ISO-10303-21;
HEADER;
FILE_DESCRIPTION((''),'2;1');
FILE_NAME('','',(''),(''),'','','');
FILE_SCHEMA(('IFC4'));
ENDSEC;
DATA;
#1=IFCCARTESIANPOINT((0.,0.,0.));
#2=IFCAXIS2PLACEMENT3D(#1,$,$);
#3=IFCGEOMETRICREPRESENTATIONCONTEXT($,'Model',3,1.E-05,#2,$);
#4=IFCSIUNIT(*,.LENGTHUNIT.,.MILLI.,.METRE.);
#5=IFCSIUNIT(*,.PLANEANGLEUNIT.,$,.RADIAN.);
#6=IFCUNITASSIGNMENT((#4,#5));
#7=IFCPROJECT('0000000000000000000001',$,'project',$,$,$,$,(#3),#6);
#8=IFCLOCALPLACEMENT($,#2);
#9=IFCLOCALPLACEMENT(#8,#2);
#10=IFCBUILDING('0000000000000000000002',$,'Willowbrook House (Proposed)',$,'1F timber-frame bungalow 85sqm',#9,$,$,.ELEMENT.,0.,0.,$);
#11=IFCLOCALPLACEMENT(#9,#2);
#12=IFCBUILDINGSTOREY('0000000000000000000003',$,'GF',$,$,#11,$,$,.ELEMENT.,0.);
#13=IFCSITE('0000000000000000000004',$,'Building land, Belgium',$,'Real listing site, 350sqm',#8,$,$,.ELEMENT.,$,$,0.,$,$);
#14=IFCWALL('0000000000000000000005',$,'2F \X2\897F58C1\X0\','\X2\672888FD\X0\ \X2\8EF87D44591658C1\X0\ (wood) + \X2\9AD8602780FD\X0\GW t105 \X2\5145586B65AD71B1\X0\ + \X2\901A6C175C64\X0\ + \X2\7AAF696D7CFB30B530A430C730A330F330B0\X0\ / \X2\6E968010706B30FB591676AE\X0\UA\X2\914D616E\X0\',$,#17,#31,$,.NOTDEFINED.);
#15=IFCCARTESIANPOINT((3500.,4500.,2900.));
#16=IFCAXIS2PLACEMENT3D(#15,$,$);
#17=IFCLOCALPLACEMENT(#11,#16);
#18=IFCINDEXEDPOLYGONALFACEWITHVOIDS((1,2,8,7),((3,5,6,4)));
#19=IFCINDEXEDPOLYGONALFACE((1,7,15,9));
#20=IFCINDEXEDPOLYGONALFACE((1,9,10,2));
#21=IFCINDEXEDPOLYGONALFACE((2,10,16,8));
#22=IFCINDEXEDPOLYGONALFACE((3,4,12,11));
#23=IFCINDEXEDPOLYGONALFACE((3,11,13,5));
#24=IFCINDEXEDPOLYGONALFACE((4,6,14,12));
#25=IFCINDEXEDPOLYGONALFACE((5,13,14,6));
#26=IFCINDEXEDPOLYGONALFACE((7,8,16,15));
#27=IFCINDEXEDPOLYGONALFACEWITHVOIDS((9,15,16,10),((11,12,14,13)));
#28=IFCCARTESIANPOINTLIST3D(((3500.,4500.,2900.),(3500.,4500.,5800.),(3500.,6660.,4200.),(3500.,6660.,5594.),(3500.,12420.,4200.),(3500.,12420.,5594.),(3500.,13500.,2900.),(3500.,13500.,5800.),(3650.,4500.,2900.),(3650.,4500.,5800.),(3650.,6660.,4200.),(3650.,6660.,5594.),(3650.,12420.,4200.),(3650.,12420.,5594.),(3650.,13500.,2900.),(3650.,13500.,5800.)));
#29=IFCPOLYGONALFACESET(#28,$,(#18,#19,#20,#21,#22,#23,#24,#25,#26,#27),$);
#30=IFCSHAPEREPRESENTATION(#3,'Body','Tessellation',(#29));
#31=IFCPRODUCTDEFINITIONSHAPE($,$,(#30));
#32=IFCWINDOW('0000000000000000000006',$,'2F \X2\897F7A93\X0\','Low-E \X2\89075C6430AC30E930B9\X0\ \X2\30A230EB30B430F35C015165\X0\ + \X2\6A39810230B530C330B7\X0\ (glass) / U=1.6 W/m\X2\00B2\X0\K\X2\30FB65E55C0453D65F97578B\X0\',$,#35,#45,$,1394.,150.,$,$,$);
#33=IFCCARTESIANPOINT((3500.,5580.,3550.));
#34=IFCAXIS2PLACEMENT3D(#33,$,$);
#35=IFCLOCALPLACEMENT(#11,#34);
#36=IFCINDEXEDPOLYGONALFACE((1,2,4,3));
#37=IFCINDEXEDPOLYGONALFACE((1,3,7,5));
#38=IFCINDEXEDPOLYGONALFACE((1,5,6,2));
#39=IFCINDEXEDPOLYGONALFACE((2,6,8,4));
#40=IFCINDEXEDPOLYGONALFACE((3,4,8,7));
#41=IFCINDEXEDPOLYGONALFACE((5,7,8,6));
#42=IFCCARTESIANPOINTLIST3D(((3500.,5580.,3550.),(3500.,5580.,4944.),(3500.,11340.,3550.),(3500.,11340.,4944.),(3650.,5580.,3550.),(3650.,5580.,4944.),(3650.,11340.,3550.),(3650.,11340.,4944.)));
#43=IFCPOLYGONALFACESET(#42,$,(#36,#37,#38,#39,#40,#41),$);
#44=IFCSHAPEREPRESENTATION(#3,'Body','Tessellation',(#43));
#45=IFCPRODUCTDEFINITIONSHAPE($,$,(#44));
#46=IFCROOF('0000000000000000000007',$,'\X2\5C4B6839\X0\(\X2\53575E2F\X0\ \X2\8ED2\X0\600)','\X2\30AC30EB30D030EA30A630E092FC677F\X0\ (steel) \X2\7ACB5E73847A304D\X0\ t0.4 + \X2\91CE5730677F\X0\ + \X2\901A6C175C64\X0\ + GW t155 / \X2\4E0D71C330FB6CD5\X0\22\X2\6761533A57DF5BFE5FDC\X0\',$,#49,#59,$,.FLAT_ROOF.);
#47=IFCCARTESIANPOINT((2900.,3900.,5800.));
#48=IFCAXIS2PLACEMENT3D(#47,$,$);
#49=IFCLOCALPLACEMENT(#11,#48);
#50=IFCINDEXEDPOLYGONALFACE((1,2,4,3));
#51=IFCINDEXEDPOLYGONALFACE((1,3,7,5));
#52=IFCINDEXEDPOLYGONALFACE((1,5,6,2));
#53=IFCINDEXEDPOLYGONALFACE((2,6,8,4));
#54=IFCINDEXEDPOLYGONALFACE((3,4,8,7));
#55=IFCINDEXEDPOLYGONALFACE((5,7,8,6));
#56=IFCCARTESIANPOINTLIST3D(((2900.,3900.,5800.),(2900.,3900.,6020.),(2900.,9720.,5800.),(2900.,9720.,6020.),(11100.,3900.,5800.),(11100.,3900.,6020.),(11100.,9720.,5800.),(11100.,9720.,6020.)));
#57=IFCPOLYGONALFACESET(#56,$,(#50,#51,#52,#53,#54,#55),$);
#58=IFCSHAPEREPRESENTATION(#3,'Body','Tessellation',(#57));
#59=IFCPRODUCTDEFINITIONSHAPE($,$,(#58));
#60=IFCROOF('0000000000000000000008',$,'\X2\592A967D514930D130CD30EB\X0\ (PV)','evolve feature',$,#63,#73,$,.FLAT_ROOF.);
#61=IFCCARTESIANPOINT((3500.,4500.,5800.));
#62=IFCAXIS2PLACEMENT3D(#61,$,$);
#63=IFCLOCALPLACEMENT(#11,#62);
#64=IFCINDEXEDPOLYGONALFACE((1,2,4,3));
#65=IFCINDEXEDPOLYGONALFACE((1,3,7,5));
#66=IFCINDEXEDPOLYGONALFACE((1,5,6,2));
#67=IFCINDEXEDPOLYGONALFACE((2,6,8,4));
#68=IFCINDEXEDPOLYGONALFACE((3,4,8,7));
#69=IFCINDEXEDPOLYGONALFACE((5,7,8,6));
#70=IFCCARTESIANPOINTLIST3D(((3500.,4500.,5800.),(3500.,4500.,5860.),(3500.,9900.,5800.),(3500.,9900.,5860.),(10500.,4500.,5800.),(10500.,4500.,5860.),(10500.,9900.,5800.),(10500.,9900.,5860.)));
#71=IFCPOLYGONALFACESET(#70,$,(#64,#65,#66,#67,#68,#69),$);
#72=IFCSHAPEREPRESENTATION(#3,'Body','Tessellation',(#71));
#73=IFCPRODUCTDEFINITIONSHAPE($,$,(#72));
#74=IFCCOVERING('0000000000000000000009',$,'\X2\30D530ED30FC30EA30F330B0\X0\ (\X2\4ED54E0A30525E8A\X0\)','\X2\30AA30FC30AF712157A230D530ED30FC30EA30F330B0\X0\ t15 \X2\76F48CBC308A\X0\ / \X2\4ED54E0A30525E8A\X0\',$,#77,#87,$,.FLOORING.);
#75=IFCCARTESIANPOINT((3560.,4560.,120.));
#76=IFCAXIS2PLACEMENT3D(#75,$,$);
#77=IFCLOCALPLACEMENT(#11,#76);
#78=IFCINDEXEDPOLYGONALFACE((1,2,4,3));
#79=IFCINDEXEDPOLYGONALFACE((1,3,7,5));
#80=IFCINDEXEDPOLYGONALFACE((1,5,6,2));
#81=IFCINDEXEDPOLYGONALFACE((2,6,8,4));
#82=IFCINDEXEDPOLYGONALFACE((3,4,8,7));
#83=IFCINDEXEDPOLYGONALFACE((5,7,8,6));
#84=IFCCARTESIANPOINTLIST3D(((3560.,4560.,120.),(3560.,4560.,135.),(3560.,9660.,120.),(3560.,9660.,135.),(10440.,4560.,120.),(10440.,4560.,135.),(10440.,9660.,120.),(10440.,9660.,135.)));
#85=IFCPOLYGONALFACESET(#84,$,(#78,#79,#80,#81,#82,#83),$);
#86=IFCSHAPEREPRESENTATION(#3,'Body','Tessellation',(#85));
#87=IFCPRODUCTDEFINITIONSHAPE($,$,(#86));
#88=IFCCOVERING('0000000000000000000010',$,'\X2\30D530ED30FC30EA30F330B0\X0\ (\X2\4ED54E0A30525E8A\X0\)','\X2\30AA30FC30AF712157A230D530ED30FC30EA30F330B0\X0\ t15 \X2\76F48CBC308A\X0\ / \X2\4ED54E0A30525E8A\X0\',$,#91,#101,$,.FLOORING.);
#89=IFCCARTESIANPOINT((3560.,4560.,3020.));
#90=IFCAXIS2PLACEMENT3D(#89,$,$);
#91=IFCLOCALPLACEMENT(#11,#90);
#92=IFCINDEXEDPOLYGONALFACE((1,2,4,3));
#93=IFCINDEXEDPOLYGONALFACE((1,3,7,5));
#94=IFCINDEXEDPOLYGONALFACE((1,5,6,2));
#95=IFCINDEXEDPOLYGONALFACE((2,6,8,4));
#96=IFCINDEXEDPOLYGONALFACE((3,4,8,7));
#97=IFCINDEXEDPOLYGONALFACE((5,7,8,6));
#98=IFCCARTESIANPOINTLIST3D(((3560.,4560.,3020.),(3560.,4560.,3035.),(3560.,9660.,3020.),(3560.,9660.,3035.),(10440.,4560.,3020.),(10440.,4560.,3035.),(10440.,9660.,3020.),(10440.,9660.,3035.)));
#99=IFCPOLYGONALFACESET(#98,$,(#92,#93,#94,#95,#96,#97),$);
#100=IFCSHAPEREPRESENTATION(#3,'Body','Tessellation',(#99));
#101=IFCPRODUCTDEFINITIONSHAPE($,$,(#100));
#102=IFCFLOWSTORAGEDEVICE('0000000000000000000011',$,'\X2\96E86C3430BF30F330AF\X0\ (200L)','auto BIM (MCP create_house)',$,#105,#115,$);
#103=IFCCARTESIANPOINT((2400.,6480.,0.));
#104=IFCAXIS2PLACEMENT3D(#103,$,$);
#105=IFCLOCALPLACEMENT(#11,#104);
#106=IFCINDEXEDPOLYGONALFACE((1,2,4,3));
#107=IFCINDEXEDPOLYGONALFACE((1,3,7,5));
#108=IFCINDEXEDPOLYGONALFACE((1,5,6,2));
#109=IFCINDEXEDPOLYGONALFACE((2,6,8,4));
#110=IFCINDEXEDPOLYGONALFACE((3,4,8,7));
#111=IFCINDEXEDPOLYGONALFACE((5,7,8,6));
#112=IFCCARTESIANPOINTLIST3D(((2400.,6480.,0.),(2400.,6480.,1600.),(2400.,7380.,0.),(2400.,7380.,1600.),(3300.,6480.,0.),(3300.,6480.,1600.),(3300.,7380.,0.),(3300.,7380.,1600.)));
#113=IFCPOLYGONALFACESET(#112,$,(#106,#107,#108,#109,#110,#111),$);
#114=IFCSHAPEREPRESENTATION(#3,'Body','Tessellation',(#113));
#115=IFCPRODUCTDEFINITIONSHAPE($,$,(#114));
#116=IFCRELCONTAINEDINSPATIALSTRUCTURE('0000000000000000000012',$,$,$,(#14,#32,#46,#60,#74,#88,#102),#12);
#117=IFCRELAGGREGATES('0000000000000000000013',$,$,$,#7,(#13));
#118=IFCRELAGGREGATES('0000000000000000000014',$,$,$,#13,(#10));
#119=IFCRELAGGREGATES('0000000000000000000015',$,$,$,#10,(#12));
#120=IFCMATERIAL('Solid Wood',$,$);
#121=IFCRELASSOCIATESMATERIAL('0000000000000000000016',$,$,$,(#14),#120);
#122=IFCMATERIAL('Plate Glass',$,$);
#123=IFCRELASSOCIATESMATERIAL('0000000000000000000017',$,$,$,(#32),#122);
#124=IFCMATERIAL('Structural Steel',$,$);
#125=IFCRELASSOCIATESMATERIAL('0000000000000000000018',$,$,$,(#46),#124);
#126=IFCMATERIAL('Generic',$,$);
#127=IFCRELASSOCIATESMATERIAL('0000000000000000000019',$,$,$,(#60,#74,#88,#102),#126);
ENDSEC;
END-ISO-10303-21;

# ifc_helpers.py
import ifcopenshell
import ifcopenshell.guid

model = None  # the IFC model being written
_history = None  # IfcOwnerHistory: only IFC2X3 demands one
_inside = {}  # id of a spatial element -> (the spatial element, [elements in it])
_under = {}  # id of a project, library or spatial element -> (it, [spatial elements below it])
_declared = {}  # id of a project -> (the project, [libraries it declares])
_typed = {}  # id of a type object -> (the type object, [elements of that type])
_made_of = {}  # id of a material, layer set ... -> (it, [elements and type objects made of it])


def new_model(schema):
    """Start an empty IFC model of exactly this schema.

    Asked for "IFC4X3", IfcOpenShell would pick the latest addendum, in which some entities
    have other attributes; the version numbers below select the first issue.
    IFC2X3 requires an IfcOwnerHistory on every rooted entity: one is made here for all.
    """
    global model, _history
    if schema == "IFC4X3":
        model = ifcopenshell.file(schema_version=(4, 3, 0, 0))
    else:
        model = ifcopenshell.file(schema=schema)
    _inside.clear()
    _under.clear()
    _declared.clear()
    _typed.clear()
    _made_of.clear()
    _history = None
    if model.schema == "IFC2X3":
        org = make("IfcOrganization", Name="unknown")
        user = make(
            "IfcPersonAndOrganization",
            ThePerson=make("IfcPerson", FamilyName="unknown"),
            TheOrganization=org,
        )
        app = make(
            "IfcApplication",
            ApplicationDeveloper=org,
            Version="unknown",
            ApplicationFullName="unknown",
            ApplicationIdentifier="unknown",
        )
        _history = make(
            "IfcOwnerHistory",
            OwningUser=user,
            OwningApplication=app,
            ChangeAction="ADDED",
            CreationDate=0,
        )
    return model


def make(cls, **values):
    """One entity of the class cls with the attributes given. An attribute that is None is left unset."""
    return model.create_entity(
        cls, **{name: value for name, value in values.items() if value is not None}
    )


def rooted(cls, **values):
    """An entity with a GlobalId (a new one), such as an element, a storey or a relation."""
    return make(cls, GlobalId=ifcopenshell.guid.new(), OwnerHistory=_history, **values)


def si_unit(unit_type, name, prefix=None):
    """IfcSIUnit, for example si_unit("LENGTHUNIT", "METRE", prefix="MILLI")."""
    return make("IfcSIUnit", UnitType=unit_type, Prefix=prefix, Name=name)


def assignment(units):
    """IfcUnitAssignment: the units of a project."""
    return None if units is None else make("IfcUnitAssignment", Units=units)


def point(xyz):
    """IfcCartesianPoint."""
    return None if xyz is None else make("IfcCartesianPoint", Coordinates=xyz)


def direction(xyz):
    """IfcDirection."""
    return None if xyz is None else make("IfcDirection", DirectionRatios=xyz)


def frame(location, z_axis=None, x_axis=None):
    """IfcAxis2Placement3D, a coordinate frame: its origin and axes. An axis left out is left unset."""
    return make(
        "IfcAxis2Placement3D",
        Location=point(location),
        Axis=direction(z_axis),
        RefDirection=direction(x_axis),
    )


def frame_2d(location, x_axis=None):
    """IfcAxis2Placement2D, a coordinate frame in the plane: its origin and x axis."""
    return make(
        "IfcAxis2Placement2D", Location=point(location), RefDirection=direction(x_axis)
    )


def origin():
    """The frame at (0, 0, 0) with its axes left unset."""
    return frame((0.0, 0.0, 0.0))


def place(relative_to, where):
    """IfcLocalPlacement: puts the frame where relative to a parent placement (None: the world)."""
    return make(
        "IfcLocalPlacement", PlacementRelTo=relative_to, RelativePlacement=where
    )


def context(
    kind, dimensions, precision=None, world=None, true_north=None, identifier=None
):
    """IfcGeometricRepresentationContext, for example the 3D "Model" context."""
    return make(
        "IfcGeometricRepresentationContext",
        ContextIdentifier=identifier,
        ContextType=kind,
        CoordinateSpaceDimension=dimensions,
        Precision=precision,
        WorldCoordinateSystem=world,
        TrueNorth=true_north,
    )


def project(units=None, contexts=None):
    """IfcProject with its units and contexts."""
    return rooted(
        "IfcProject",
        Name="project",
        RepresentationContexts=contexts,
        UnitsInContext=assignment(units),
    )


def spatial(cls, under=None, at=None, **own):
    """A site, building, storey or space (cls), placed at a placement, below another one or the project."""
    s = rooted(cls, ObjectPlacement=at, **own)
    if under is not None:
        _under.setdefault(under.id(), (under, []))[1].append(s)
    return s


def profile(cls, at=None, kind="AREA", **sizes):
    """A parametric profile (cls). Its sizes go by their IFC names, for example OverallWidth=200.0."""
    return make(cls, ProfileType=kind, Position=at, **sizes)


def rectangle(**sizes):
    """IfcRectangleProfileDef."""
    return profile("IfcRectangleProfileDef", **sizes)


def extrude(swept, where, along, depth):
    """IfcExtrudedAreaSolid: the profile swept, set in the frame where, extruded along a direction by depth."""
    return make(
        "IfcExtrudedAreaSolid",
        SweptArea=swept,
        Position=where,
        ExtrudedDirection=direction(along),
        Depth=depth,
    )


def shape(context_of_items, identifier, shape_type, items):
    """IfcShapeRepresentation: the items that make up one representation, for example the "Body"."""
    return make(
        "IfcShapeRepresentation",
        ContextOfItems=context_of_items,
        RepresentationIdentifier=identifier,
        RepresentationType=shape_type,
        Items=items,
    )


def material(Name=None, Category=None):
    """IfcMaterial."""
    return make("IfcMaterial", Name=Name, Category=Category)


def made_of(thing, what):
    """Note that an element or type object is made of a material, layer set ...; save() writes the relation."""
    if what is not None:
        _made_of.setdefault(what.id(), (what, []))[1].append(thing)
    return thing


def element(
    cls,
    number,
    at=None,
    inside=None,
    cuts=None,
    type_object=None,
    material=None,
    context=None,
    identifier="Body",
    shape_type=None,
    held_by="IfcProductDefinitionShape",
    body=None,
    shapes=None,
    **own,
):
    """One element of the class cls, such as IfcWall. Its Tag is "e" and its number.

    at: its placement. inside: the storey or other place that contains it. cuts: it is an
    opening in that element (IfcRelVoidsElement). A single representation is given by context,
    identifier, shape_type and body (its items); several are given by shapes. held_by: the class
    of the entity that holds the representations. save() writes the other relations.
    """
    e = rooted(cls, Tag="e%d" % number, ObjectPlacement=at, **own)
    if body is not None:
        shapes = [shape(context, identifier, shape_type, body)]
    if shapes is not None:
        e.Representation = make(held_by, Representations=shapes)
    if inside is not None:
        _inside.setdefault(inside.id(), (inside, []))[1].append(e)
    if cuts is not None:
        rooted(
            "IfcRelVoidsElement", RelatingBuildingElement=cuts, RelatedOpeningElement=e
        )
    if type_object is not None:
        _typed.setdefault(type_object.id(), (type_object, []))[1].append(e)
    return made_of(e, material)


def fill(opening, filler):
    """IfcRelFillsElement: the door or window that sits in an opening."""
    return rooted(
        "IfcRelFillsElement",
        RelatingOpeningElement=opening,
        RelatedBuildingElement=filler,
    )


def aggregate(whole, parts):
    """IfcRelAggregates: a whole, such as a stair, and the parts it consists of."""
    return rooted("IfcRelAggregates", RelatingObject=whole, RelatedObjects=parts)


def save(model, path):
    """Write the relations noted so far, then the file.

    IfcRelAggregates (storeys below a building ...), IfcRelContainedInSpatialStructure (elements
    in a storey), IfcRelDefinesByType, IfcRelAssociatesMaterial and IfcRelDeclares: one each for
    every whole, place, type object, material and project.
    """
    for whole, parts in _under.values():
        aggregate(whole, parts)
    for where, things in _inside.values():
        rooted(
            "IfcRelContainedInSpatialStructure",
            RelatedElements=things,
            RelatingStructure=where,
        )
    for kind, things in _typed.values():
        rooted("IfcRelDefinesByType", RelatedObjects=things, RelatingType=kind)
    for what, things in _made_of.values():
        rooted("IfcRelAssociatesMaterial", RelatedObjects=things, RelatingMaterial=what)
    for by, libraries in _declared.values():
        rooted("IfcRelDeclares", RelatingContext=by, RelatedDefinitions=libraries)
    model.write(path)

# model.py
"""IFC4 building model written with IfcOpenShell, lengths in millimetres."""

from ifc_helpers import new_model, si_unit, frame, frame_2d, origin, place, context, project, spatial, rectangle, extrude, material, element, fill, save


model = new_model("IFC4")

# Units and contexts
model_context = context("Model", 3, precision=1e-05, world=origin())
ifc_project = project(units=[si_unit("LENGTHUNIT", "METRE", prefix="MILLI"), si_unit("PLANEANGLEUNIT", "RADIAN")], contexts=[model_context])

# Site, building, storey
site_placement = place(None, origin())
site = spatial("IfcSite", under=ifc_project, at=site_placement, Name="Building land, Belgium", ObjectType="Real listing site, 350sqm", CompositionType="ELEMENT", RefElevation=0.0)
building_placement = place(site_placement, origin())
building = spatial("IfcBuilding", under=site, at=building_placement, Name="Willowbrook House (Proposed)", ObjectType="1F timber-frame bungalow 85sqm", CompositionType="ELEMENT", ElevationOfRefHeight=0.0, ElevationOfTerrain=0.0)
storey_placement = place(building_placement, origin())
storey = spatial("IfcBuildingStorey", under=building, at=storey_placement, Name="GF", CompositionType="ELEMENT", Elevation=0.0)

# Shared definitions
ifc_material_1 = material(Name="Solid Wood")
ifc_material_2 = material(Name="Generic")

# Shared definitions
ifc_material_3 = material(Name="Plate Glass")

# Wall, opening, window
wall_1_placement = place(storey_placement, frame((3500.0, 4500.0, 2900.0)))
wall_1 = element("IfcWall", 1, at=wall_1_placement, inside=storey, material=ifc_material_1, Name="2F 西壁", Description="木製 軸組外壁 (wood) + 高性能GW t105 充填断熱 + 通気層 + 窯業系サイディング / 準耐火・外皮UA配慮", PredefinedType="NOTDEFINED", context=model_context, shape_type="SweptSolid", body=[
    extrude(rectangle(XDim=150.0, YDim=9000.0, at=frame_2d((75.0, 4500.0))), frame((3500.0, 4500.0, 2900.0)), (0.0, 0.0, 1.0), 2900.0),
])
opening_1_placement = place(storey_placement, frame((3500.0, 5580.0, 3550.0)))
opening_1 = element("IfcOpeningElement", 2, at=opening_1_placement, cuts=wall_1, PredefinedType="NOTDEFINED", context=model_context, shape_type="SweptSolid", body=[
    extrude(rectangle(XDim=150.0, YDim=5760.0, at=frame_2d((75.0, 2880.0))), frame((3500.0, 5580.0, 3550.0)), (0.0, 0.0, 1.0), 1394.0),
])
window_1_placement = place(storey_placement, frame((3500.0, 5580.0, 3550.0)))
window_1 = element("IfcWindow", 3, at=window_1_placement, inside=storey, material=ifc_material_3, Name="2F 西窓", Description="Low-E 複層ガラス アルゴン封入 + 樹脂サッシ (glass) / U=1.6 W/m²K・日射取得型", OverallHeight=1394.0, OverallWidth=150.0, context=model_context, shape_type="SweptSolid", body=[
    extrude(rectangle(XDim=150.0, YDim=5760.0, at=frame_2d((75.0, 2880.0))), frame((3500.0, 5580.0, 3550.0)), (0.0, 0.0, 1.0), 1394.0),
])
fill(opening_1, window_1)

# Roofs
ifc_material_4 = material(Name="Structural Steel")
for number, where, name in (
    (4, (2900.0, 3900.0, 5800.0), "屋根(南帯 軒600)"),
):
    element("IfcRoof", number, at=place(storey_placement, frame(where)), inside=storey, material=ifc_material_4, Name=name, Description="ガルバリウム鋼板 (steel) 立平葺き t0.4 + 野地板 + 通気層 + GW t155 / 不燃・法22条区域対応", PredefinedType="FLAT_ROOF", context=model_context, shape_type="SweptSolid", body=[
        extrude(rectangle(XDim=8200.0, YDim=5820.0, at=frame_2d((4100.0, 2910.0))), frame((2900.0, 3900.0, 5800.0)), (0.0, 0.0, 1.0), 220.0),
    ])
roof_placement = place(storey_placement, frame((3500.0, 4500.0, 5800.0)))
element("IfcRoof", 5, at=roof_placement, inside=storey, material=ifc_material_2, Name="太陽光パネル (PV)", Description="evolve feature", PredefinedType="FLAT_ROOF", context=model_context, shape_type="SweptSolid", body=[
    extrude(rectangle(XDim=7000.0, YDim=5400.0, at=frame_2d((3500.0, 2700.0))), frame((3500.0, 4500.0, 5800.0)), (0.0, 0.0, 1.0), 60.0),
])

# Coverings
covering_1_placement = place(storey_placement, frame((3560.0, 4560.0, 120.0)))
element("IfcCovering", 6, at=covering_1_placement, inside=storey, material=ifc_material_2, Name="フローリング (仕上げ床)", Description="オーク無垢フローリング t15 直貼り / 仕上げ床", PredefinedType="FLOORING", context=model_context, shape_type="SweptSolid", body=[
    extrude(rectangle(XDim=6880.0, YDim=5100.0, at=frame_2d((3440.0, 2550.0))), frame((3560.0, 4560.0, 120.0)), (0.0, 0.0, 1.0), 15.0),
])
covering_2_placement = place(storey_placement, frame((3560.0, 4560.0, 3020.0)))
element("IfcCovering", 7, at=covering_2_placement, inside=storey, material=ifc_material_2, Name="フローリング (仕上げ床)", Description="オーク無垢フローリング t15 直貼り / 仕上げ床", PredefinedType="FLOORING", context=model_context, shape_type="SweptSolid", body=[
    extrude(rectangle(XDim=6880.0, YDim=5100.0, at=frame_2d((3440.0, 2550.0))), frame((3560.0, 4560.0, 3020.0)), (0.0, 0.0, 1.0), 15.0),
])

# Flow storage device
flow_storage_device_placement = place(storey_placement, frame((2400.0, 6480.0, 0.0)))
element("IfcFlowStorageDevice", 8, at=flow_storage_device_placement, inside=storey, material=ifc_material_2, Name="雨水タンク (200L)", Description="auto BIM (MCP create_house)", context=model_context, shape_type="SweptSolid", body=[
    extrude(rectangle(XDim=900.0, YDim=900.0, at=frame_2d((450.0, 450.0))), frame((2400.0, 6480.0, 0.0)), (0.0, 0.0, 1.0), 1600.0),
])

save(model, "model.ifc")
